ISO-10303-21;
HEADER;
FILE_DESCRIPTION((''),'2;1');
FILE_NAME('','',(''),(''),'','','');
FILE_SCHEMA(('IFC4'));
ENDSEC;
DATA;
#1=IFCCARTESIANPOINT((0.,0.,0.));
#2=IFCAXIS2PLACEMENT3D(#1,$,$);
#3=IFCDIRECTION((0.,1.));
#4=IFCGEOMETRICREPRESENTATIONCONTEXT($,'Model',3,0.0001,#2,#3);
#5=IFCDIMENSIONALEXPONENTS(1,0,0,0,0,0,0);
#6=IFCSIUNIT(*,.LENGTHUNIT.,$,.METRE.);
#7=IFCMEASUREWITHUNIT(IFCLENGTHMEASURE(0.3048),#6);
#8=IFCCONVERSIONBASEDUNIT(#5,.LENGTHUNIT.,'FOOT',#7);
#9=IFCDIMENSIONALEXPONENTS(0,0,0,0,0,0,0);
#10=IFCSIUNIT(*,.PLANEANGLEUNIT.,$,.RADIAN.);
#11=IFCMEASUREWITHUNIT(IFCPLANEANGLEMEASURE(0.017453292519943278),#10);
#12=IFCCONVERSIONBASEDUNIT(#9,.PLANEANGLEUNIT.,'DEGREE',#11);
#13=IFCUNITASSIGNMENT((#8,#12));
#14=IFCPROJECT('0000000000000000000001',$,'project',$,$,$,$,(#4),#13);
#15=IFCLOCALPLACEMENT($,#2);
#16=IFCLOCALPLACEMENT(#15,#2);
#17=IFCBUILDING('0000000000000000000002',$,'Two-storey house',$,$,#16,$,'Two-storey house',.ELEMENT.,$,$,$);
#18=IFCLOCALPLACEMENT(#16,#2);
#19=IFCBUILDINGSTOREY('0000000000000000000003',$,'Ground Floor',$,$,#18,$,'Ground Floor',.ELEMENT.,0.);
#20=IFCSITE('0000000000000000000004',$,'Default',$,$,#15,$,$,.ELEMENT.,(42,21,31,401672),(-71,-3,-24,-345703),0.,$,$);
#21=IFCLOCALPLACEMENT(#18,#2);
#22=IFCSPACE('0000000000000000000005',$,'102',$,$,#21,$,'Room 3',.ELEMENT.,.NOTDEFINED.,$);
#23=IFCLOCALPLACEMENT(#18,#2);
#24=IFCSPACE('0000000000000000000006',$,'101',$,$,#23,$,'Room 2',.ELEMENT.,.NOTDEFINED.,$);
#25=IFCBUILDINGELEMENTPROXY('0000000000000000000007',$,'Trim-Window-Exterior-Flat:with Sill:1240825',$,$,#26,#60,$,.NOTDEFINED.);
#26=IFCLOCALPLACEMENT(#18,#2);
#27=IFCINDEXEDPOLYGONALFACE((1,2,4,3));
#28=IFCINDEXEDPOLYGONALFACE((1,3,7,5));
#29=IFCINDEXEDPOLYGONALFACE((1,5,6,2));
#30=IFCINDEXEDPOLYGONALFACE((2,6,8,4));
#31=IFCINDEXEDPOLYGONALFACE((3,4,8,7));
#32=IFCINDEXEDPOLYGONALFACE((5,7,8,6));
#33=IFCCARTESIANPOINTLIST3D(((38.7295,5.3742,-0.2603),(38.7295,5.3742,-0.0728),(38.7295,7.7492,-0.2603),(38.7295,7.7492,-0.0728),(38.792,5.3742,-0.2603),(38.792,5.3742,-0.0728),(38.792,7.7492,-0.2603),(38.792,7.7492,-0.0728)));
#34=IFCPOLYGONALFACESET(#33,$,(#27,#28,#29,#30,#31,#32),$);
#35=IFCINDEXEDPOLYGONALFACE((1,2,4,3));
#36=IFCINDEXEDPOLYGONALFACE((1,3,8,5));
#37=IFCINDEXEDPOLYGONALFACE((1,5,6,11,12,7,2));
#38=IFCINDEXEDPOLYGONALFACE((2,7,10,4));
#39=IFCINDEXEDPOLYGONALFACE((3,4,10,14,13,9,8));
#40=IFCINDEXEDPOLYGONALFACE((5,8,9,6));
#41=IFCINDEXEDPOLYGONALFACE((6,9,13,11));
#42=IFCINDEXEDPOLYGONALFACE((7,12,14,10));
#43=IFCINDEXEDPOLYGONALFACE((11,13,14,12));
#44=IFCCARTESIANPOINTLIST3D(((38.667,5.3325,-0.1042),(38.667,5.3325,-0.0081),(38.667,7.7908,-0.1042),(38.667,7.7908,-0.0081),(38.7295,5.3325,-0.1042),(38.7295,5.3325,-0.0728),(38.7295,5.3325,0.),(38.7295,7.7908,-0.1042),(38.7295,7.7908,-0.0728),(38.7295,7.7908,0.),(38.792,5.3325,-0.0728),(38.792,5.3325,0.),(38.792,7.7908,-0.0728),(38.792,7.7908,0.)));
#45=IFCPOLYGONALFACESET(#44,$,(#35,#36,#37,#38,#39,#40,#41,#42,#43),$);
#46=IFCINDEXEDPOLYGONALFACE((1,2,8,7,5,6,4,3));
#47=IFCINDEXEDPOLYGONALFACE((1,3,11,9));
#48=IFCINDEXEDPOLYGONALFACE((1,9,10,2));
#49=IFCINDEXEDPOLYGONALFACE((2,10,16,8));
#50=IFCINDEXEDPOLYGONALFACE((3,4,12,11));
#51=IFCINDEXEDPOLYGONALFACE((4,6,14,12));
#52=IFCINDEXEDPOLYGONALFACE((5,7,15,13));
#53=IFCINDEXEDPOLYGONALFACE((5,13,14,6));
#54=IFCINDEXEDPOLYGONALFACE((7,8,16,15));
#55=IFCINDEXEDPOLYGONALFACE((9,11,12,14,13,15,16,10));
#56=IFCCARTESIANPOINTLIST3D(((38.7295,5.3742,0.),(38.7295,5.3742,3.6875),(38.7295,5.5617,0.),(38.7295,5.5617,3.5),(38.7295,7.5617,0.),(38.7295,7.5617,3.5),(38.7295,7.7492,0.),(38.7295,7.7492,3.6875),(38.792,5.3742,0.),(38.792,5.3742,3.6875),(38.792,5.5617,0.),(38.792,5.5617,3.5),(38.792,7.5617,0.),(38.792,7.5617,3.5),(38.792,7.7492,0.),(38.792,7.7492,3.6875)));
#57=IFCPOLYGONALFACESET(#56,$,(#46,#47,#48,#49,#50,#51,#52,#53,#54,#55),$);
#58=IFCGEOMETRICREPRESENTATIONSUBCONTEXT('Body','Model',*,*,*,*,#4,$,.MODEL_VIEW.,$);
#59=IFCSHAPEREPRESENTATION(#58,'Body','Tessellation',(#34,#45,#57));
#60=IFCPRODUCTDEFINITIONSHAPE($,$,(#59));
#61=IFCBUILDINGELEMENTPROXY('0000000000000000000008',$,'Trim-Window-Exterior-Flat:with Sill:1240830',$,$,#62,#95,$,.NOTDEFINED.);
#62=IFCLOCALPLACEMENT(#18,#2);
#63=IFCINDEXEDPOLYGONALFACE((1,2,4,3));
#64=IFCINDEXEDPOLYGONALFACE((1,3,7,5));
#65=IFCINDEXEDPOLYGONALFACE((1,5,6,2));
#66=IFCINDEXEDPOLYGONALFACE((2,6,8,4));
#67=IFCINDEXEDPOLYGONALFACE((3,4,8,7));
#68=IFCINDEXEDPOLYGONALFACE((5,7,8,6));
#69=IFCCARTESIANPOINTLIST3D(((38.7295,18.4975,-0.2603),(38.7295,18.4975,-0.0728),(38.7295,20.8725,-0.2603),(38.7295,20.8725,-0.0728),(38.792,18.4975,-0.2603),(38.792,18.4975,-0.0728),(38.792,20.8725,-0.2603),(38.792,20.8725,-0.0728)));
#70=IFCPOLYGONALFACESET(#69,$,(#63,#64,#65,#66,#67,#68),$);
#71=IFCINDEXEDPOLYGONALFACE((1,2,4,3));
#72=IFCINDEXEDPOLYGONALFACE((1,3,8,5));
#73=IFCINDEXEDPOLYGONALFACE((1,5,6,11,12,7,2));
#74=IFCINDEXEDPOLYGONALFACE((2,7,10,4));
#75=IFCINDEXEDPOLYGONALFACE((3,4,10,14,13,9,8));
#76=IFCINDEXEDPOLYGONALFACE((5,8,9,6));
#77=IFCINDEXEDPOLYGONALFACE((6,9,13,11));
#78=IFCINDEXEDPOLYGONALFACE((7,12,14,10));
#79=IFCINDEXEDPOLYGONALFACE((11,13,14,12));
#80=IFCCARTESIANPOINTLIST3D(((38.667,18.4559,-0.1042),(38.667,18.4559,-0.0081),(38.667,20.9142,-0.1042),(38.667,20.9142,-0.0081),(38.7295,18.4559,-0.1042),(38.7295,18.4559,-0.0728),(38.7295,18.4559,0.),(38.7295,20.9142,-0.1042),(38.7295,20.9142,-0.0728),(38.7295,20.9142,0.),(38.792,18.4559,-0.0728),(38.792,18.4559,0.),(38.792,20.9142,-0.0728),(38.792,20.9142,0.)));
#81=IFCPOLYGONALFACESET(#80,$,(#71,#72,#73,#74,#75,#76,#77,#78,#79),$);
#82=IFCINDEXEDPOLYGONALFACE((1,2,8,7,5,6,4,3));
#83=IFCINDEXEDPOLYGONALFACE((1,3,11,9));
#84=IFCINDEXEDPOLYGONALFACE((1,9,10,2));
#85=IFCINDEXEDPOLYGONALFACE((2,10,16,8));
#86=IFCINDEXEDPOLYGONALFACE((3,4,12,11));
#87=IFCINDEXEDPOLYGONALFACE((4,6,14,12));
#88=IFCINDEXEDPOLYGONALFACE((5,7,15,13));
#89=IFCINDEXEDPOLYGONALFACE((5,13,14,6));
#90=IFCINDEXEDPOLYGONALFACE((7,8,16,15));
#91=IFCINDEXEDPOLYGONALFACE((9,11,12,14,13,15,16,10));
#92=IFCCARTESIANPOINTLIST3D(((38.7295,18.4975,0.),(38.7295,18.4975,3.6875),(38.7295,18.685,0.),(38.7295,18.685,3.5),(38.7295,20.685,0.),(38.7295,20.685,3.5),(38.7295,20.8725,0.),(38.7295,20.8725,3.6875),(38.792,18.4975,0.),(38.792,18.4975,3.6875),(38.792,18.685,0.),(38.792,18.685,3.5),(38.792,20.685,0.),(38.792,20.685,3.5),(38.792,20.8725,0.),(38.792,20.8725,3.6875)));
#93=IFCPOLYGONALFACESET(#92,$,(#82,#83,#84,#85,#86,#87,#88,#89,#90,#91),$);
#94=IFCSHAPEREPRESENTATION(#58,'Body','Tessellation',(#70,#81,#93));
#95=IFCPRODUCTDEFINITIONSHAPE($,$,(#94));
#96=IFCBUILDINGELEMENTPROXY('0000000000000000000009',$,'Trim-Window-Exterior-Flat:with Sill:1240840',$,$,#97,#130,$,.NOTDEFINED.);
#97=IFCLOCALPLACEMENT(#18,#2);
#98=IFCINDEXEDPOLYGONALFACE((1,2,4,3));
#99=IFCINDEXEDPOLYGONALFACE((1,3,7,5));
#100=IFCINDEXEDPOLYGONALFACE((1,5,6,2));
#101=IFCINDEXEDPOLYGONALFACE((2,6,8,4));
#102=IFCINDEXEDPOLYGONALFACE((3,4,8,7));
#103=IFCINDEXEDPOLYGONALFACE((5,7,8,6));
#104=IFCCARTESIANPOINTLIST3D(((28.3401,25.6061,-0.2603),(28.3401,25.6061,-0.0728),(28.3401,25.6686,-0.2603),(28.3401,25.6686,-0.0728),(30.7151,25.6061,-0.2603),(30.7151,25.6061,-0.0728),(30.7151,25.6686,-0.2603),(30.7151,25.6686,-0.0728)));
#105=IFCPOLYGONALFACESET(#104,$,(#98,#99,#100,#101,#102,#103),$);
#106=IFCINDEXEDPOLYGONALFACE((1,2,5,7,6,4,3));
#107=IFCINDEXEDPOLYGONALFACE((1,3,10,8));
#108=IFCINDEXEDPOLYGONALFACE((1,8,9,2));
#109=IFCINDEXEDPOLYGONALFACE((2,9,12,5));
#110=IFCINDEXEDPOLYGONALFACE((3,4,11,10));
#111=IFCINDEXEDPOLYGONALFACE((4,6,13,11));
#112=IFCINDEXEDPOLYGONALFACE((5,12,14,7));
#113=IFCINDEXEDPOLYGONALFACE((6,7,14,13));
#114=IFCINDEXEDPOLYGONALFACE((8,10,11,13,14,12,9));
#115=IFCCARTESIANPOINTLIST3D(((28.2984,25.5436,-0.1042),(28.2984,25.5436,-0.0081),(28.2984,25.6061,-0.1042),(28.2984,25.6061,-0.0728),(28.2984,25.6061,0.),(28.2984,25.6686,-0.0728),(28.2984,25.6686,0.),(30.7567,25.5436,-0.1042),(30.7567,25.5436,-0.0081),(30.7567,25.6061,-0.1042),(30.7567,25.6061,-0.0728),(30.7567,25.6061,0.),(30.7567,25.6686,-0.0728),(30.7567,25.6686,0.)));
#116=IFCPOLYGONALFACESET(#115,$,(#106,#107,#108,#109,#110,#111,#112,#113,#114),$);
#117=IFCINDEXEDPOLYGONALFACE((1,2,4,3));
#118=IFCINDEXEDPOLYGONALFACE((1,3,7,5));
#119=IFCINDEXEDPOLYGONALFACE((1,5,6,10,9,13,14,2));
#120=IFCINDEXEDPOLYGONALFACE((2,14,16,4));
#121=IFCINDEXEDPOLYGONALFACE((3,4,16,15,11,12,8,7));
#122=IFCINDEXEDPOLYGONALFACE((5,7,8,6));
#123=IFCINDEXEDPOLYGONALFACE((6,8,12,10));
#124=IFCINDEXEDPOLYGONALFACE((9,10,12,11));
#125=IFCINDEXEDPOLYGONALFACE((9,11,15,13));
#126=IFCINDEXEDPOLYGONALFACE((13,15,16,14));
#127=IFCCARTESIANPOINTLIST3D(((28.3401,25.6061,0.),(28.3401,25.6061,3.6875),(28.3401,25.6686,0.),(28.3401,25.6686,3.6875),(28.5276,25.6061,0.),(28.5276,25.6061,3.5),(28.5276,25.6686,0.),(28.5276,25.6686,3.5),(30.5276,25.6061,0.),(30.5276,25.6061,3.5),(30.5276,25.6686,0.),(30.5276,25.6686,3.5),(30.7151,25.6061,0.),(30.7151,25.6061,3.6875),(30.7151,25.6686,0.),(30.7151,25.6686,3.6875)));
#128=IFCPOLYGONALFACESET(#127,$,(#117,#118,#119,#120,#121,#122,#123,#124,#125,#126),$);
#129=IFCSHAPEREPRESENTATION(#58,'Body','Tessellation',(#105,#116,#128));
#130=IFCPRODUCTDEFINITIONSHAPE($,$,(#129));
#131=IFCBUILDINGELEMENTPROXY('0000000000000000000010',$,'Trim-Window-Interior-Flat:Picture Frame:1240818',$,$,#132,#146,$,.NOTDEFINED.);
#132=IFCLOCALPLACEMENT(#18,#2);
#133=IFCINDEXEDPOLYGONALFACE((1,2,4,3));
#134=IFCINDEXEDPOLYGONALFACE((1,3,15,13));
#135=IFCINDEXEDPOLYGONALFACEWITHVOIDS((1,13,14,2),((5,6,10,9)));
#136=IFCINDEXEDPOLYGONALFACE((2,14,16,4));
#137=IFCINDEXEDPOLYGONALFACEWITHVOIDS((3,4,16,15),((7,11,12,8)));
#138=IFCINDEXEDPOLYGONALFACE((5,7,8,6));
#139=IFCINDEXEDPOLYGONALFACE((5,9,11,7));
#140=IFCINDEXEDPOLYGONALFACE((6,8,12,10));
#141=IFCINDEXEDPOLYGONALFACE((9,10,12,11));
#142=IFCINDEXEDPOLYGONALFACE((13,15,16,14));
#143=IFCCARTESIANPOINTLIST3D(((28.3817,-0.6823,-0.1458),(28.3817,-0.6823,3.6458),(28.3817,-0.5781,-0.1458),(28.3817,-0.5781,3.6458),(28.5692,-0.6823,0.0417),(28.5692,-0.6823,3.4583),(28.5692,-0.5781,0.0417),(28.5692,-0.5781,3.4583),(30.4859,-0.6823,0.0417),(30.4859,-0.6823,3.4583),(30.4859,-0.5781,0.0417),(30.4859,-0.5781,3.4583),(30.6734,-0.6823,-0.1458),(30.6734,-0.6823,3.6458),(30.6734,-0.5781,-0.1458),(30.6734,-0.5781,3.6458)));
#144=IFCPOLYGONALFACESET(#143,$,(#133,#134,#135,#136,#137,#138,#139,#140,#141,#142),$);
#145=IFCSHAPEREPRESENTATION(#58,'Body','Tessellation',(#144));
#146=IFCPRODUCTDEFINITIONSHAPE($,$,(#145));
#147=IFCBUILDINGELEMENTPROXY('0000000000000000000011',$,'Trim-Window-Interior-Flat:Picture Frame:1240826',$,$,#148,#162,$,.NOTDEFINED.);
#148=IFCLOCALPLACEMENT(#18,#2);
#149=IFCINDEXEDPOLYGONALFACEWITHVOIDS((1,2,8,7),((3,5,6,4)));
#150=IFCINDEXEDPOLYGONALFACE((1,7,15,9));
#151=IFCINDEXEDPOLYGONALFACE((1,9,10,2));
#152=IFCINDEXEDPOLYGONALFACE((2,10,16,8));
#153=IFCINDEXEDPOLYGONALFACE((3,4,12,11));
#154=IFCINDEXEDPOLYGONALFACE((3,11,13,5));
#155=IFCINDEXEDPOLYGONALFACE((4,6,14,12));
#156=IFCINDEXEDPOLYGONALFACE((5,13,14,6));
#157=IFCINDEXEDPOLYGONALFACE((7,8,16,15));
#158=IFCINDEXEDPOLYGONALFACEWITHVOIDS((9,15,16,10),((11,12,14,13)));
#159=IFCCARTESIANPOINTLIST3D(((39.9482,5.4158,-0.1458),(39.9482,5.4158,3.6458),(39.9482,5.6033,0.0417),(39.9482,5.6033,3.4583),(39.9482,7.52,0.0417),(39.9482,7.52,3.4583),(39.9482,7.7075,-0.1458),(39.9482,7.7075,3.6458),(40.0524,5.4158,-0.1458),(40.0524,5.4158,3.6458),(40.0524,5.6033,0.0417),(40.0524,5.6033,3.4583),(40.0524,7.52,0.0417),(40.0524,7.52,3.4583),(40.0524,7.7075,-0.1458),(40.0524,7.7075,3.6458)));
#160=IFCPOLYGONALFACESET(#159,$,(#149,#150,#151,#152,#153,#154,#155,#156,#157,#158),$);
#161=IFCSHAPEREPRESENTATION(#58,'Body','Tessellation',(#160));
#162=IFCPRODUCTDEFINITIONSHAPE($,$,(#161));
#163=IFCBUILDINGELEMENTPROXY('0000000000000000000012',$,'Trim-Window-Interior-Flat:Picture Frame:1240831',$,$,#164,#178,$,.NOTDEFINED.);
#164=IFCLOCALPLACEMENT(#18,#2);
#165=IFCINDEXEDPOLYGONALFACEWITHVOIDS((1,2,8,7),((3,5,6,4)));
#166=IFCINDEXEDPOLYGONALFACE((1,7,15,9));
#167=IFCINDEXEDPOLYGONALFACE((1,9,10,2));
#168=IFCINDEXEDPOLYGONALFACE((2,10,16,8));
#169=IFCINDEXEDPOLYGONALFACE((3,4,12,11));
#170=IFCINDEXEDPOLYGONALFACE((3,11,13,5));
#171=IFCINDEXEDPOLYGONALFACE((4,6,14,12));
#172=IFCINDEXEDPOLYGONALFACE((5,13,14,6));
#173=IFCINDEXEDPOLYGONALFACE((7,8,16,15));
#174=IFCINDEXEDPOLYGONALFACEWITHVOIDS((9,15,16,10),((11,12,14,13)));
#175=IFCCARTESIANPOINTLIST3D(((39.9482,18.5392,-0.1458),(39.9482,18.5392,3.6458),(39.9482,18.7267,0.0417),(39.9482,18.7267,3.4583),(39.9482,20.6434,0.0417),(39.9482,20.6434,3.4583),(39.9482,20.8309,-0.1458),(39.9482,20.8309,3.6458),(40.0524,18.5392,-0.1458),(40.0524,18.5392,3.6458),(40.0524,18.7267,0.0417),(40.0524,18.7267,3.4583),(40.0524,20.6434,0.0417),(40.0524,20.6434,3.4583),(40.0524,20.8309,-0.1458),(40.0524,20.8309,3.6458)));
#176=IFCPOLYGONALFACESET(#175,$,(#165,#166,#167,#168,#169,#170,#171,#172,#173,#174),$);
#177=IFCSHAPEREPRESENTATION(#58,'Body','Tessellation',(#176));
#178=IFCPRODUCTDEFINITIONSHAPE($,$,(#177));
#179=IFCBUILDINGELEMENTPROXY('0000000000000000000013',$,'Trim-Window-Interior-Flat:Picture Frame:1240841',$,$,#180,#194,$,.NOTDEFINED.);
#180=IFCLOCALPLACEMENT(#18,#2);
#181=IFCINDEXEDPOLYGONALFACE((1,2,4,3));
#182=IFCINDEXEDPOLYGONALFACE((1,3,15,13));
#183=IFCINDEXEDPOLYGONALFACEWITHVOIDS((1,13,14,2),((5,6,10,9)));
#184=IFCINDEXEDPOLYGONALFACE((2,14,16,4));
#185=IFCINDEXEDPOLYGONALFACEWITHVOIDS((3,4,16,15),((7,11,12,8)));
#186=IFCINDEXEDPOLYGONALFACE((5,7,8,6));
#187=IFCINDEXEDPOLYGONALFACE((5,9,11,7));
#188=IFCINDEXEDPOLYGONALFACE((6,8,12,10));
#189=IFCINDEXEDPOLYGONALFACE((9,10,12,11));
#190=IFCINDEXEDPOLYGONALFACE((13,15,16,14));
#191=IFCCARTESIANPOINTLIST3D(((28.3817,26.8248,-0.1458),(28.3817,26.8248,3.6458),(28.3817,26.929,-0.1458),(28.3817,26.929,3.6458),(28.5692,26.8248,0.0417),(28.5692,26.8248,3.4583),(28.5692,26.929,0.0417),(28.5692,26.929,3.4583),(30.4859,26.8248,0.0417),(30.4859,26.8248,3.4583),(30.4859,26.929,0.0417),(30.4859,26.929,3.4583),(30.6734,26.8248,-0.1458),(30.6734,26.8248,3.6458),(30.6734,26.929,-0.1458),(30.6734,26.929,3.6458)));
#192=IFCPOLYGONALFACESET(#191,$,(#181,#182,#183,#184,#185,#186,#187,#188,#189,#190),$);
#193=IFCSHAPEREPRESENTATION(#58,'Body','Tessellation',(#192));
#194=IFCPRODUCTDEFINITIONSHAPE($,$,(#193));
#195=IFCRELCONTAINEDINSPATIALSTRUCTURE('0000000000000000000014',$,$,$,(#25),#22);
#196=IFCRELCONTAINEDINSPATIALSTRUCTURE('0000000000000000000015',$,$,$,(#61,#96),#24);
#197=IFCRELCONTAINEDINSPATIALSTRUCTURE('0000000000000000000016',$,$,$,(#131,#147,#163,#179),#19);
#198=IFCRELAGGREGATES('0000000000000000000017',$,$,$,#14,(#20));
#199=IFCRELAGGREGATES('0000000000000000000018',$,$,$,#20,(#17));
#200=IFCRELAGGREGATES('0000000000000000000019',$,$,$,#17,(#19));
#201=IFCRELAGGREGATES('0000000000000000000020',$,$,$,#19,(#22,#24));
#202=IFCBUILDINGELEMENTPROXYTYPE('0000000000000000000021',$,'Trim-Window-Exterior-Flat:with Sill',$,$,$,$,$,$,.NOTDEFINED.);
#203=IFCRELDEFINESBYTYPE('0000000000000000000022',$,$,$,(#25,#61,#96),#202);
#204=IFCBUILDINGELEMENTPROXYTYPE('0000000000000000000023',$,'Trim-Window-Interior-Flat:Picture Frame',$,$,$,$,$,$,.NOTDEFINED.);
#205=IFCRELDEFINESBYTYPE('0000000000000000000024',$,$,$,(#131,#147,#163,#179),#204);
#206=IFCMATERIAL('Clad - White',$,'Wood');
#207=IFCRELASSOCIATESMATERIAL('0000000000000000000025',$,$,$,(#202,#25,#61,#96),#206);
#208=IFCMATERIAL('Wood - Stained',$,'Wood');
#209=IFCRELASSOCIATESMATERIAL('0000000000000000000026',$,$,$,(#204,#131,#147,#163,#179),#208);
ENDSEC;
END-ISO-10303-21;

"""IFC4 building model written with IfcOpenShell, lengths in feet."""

from ifc_helpers import new_model, entity, si_unit, converted_unit, direction, frame, origin, place, context, subcontext, project, spatial, indexed_curve, outline, extrude, source, transform, mapped, material, type_object, type_shapes, element, save


model = new_model("IFC4")

# Units and contexts
model_context = context("Model", 3, precision=0.0001, world=origin(), true_north=direction((0.0, 1.0)))
body_context = subcontext(model_context, "Body", "Model", "MODEL_VIEW")
ifc_project = project(units=[converted_unit("LENGTHUNIT", "FOOT", entity("IfcLengthMeasure", 0.3048), si_unit("LENGTHUNIT", "METRE"), dimensions=[1, 0, 0, 0, 0, 0, 0]), converted_unit("PLANEANGLEUNIT", "DEGREE", entity("IfcPlaneAngleMeasure", 0.017453292519943278), si_unit("PLANEANGLEUNIT", "RADIAN"), dimensions=[0, 0, 0, 0, 0, 0, 0])], contexts=[model_context])

# Site, building, storey
site_placement = place(None, origin())
site = spatial("IfcSite", under=ifc_project, at=site_placement, Name="Default", CompositionType="ELEMENT", RefLatitude=(42, 21, 31, 401672), RefLongitude=(-71, -3, -24, -345703), RefElevation=0.0)
building_placement = place(site_placement, origin())
building = spatial("IfcBuilding", under=site, at=building_placement, Name="Two-storey house", LongName="Two-storey house", CompositionType="ELEMENT")
storey_placement = place(building_placement, origin())
storey = spatial("IfcBuildingStorey", under=building, at=storey_placement, Name="Ground Floor", LongName="Ground Floor", CompositionType="ELEMENT", Elevation=0.0)

# Shared definitions
ifc_material_1 = material(Name="Wood - Stained", Category="Wood")

# Shared definitions
ifc_material_2 = material(Name="Clad - White", Category="Wood")

# Shared definitions
space_1_placement = place(storey_placement, origin())
space_1 = spatial("IfcSpace", under=storey, at=space_1_placement, Name="102", LongName="Room 3", CompositionType="ELEMENT", PredefinedType="NOTDEFINED")

# Building element proxy
building_element_proxy_type_1 = type_object("IfcBuildingElementProxyType", Name="Trim-Window-Exterior-Flat:with Sill", PredefinedType="NOTDEFINED", material=ifc_material_2)
shared_shape_1 = source(origin(), body_context, "Body", "SweptSolid", [
    extrude(outline(indexed_curve([(-1.1875, -0.0938), (1.1875, -0.0938), (1.1875, 0.0938), (-1.1875, 0.0938), (-1.1875, -0.0938)], self_intersect=False)), frame((0.0, -3.6665, 0.0), z_axis=(0.0, 0.0, 1.0), x_axis=(-1.0, 0.0, 0.0)), (0.0, 0.0, 1.0), 0.0625),
    extrude(outline(indexed_curve([(-0.0625, -0.0525), (0.0, -0.0525), (0.0, -0.0211), (0.0625, -0.0211), (0.0625, 0.0517), (0.0, 0.0517), (-0.0625, 0.0436), (-0.0625, -0.0525)], self_intersect=False)), frame((-1.2292, -3.5517, 0.0625), z_axis=(1.0, 0.0, 0.0), x_axis=(0.0, 0.0, -1.0)), (0.0, 0.0, 1.0), 2.4583),
    extrude(outline(indexed_curve([(-1.8906, -1.1875), (1.7969, -1.1875), (1.7969, -1.0), (-1.7031, -1.0), (-1.7031, 1.0), (1.7969, 1.0), (1.7969, 1.1875), (-1.8906, 1.1875), (-1.8906, -1.1875)], self_intersect=False)), frame((0.0, -1.7031, 0.0), z_axis=(0.0, 0.0, 1.0), x_axis=(0.0, -1.0, 0.0)), (0.0, 0.0, 1.0), 0.0625),
])
type_shapes(building_element_proxy_type_1, [shared_shape_1])
for number, where, z_axis, x_axis, name in (
    (1, (38.792, 6.5617, 3.5), (-1.0, 0.0, 0.0), (0.0, -1.0, 0.0), "Trim-Window-Exterior-Flat:with Sill:1240825"),
):
    element("IfcBuildingElementProxy", number, at=place(space_1_placement, frame(where, z_axis=z_axis, x_axis=x_axis)), inside=space_1, type_object=building_element_proxy_type_1, material=ifc_material_2, Name=name, PredefinedType="NOTDEFINED", context=body_context, shape_type="MappedRepresentation", body=[
        mapped(shared_shape_1, transform((0.0, 0.0, 0.0), scale=1.0)),
    ])

# Shared definitions
space_2_placement = place(storey_placement, origin())
space_2 = spatial("IfcSpace", under=storey, at=space_2_placement, Name="101", LongName="Room 2", CompositionType="ELEMENT", PredefinedType="NOTDEFINED")

# Building element proxies
for number, where, z_axis, x_axis, name in (
    (2, (38.792, 19.685, 3.5), (-1.0, 0.0, 0.0), (0.0, -1.0, 0.0), "Trim-Window-Exterior-Flat:with Sill:1240830"),
    (3, (29.5276, 25.6686, 3.5), (0.0, -1.0, 0.0), (1.0, 0.0, 0.0), "Trim-Window-Exterior-Flat:with Sill:1240840"),
):
    element("IfcBuildingElementProxy", number, at=place(space_2_placement, frame(where, z_axis=z_axis, x_axis=x_axis)), inside=space_2, type_object=building_element_proxy_type_1, material=ifc_material_2, Name=name, PredefinedType="NOTDEFINED", context=body_context, shape_type="MappedRepresentation", body=[
        mapped(shared_shape_1, transform((0.0, 0.0, 0.0), scale=1.0)),
    ])
building_element_proxy_type_2 = type_object("IfcBuildingElementProxyType", Name="Trim-Window-Interior-Flat:Picture Frame", PredefinedType="NOTDEFINED", material=ifc_material_1)
shared_shape_2 = source(origin(), body_context, "Body", "SweptSolid", [
    extrude(outline(indexed_curve([(-1.1458, -1.8958), (1.1458, -1.8958), (1.1458, 1.8958), (-1.1458, 1.8958), (-1.1458, -1.8958)], self_intersect=False), holes=[indexed_curve([(-0.9583, -1.7083), (-0.9583, 1.7083), (0.9583, 1.7083), (0.9583, -1.7083), (-0.9583, -1.7083)], self_intersect=False)]), frame((0.0, -1.75, 0.0), z_axis=(0.0, 0.0, 1.0), x_axis=(-1.0, 0.0, 0.0)), (0.0, 0.0, 1.0), 0.1042),
])
type_shapes(building_element_proxy_type_2, [shared_shape_2])
for number, where, z_axis, x_axis, name in (
    (4, (29.5276, -0.5781, 3.5), (0.0, -1.0, 0.0), (1.0, 0.0, 0.0), "Trim-Window-Interior-Flat:Picture Frame:1240818"),
    (5, (39.9482, 6.5617, 3.5), (1.0, 0.0, 0.0), (0.0, 1.0, 0.0), "Trim-Window-Interior-Flat:Picture Frame:1240826"),
    (6, (39.9482, 19.685, 3.5), (1.0, 0.0, 0.0), (0.0, 1.0, 0.0), "Trim-Window-Interior-Flat:Picture Frame:1240831"),
    (7, (29.5276, 26.8248, 3.5), (0.0, 1.0, 0.0), (-1.0, 0.0, 0.0), "Trim-Window-Interior-Flat:Picture Frame:1240841"),
):
    element("IfcBuildingElementProxy", number, at=place(storey_placement, frame(where, z_axis=z_axis, x_axis=x_axis)), inside=storey, type_object=building_element_proxy_type_2, material=ifc_material_1, Name=name, PredefinedType="NOTDEFINED", context=body_context, shape_type="MappedRepresentation", body=[
        mapped(shared_shape_2, transform((0.0, 0.0, 0.0), scale=1.0)),
    ])

save(model, "model.ifc")
